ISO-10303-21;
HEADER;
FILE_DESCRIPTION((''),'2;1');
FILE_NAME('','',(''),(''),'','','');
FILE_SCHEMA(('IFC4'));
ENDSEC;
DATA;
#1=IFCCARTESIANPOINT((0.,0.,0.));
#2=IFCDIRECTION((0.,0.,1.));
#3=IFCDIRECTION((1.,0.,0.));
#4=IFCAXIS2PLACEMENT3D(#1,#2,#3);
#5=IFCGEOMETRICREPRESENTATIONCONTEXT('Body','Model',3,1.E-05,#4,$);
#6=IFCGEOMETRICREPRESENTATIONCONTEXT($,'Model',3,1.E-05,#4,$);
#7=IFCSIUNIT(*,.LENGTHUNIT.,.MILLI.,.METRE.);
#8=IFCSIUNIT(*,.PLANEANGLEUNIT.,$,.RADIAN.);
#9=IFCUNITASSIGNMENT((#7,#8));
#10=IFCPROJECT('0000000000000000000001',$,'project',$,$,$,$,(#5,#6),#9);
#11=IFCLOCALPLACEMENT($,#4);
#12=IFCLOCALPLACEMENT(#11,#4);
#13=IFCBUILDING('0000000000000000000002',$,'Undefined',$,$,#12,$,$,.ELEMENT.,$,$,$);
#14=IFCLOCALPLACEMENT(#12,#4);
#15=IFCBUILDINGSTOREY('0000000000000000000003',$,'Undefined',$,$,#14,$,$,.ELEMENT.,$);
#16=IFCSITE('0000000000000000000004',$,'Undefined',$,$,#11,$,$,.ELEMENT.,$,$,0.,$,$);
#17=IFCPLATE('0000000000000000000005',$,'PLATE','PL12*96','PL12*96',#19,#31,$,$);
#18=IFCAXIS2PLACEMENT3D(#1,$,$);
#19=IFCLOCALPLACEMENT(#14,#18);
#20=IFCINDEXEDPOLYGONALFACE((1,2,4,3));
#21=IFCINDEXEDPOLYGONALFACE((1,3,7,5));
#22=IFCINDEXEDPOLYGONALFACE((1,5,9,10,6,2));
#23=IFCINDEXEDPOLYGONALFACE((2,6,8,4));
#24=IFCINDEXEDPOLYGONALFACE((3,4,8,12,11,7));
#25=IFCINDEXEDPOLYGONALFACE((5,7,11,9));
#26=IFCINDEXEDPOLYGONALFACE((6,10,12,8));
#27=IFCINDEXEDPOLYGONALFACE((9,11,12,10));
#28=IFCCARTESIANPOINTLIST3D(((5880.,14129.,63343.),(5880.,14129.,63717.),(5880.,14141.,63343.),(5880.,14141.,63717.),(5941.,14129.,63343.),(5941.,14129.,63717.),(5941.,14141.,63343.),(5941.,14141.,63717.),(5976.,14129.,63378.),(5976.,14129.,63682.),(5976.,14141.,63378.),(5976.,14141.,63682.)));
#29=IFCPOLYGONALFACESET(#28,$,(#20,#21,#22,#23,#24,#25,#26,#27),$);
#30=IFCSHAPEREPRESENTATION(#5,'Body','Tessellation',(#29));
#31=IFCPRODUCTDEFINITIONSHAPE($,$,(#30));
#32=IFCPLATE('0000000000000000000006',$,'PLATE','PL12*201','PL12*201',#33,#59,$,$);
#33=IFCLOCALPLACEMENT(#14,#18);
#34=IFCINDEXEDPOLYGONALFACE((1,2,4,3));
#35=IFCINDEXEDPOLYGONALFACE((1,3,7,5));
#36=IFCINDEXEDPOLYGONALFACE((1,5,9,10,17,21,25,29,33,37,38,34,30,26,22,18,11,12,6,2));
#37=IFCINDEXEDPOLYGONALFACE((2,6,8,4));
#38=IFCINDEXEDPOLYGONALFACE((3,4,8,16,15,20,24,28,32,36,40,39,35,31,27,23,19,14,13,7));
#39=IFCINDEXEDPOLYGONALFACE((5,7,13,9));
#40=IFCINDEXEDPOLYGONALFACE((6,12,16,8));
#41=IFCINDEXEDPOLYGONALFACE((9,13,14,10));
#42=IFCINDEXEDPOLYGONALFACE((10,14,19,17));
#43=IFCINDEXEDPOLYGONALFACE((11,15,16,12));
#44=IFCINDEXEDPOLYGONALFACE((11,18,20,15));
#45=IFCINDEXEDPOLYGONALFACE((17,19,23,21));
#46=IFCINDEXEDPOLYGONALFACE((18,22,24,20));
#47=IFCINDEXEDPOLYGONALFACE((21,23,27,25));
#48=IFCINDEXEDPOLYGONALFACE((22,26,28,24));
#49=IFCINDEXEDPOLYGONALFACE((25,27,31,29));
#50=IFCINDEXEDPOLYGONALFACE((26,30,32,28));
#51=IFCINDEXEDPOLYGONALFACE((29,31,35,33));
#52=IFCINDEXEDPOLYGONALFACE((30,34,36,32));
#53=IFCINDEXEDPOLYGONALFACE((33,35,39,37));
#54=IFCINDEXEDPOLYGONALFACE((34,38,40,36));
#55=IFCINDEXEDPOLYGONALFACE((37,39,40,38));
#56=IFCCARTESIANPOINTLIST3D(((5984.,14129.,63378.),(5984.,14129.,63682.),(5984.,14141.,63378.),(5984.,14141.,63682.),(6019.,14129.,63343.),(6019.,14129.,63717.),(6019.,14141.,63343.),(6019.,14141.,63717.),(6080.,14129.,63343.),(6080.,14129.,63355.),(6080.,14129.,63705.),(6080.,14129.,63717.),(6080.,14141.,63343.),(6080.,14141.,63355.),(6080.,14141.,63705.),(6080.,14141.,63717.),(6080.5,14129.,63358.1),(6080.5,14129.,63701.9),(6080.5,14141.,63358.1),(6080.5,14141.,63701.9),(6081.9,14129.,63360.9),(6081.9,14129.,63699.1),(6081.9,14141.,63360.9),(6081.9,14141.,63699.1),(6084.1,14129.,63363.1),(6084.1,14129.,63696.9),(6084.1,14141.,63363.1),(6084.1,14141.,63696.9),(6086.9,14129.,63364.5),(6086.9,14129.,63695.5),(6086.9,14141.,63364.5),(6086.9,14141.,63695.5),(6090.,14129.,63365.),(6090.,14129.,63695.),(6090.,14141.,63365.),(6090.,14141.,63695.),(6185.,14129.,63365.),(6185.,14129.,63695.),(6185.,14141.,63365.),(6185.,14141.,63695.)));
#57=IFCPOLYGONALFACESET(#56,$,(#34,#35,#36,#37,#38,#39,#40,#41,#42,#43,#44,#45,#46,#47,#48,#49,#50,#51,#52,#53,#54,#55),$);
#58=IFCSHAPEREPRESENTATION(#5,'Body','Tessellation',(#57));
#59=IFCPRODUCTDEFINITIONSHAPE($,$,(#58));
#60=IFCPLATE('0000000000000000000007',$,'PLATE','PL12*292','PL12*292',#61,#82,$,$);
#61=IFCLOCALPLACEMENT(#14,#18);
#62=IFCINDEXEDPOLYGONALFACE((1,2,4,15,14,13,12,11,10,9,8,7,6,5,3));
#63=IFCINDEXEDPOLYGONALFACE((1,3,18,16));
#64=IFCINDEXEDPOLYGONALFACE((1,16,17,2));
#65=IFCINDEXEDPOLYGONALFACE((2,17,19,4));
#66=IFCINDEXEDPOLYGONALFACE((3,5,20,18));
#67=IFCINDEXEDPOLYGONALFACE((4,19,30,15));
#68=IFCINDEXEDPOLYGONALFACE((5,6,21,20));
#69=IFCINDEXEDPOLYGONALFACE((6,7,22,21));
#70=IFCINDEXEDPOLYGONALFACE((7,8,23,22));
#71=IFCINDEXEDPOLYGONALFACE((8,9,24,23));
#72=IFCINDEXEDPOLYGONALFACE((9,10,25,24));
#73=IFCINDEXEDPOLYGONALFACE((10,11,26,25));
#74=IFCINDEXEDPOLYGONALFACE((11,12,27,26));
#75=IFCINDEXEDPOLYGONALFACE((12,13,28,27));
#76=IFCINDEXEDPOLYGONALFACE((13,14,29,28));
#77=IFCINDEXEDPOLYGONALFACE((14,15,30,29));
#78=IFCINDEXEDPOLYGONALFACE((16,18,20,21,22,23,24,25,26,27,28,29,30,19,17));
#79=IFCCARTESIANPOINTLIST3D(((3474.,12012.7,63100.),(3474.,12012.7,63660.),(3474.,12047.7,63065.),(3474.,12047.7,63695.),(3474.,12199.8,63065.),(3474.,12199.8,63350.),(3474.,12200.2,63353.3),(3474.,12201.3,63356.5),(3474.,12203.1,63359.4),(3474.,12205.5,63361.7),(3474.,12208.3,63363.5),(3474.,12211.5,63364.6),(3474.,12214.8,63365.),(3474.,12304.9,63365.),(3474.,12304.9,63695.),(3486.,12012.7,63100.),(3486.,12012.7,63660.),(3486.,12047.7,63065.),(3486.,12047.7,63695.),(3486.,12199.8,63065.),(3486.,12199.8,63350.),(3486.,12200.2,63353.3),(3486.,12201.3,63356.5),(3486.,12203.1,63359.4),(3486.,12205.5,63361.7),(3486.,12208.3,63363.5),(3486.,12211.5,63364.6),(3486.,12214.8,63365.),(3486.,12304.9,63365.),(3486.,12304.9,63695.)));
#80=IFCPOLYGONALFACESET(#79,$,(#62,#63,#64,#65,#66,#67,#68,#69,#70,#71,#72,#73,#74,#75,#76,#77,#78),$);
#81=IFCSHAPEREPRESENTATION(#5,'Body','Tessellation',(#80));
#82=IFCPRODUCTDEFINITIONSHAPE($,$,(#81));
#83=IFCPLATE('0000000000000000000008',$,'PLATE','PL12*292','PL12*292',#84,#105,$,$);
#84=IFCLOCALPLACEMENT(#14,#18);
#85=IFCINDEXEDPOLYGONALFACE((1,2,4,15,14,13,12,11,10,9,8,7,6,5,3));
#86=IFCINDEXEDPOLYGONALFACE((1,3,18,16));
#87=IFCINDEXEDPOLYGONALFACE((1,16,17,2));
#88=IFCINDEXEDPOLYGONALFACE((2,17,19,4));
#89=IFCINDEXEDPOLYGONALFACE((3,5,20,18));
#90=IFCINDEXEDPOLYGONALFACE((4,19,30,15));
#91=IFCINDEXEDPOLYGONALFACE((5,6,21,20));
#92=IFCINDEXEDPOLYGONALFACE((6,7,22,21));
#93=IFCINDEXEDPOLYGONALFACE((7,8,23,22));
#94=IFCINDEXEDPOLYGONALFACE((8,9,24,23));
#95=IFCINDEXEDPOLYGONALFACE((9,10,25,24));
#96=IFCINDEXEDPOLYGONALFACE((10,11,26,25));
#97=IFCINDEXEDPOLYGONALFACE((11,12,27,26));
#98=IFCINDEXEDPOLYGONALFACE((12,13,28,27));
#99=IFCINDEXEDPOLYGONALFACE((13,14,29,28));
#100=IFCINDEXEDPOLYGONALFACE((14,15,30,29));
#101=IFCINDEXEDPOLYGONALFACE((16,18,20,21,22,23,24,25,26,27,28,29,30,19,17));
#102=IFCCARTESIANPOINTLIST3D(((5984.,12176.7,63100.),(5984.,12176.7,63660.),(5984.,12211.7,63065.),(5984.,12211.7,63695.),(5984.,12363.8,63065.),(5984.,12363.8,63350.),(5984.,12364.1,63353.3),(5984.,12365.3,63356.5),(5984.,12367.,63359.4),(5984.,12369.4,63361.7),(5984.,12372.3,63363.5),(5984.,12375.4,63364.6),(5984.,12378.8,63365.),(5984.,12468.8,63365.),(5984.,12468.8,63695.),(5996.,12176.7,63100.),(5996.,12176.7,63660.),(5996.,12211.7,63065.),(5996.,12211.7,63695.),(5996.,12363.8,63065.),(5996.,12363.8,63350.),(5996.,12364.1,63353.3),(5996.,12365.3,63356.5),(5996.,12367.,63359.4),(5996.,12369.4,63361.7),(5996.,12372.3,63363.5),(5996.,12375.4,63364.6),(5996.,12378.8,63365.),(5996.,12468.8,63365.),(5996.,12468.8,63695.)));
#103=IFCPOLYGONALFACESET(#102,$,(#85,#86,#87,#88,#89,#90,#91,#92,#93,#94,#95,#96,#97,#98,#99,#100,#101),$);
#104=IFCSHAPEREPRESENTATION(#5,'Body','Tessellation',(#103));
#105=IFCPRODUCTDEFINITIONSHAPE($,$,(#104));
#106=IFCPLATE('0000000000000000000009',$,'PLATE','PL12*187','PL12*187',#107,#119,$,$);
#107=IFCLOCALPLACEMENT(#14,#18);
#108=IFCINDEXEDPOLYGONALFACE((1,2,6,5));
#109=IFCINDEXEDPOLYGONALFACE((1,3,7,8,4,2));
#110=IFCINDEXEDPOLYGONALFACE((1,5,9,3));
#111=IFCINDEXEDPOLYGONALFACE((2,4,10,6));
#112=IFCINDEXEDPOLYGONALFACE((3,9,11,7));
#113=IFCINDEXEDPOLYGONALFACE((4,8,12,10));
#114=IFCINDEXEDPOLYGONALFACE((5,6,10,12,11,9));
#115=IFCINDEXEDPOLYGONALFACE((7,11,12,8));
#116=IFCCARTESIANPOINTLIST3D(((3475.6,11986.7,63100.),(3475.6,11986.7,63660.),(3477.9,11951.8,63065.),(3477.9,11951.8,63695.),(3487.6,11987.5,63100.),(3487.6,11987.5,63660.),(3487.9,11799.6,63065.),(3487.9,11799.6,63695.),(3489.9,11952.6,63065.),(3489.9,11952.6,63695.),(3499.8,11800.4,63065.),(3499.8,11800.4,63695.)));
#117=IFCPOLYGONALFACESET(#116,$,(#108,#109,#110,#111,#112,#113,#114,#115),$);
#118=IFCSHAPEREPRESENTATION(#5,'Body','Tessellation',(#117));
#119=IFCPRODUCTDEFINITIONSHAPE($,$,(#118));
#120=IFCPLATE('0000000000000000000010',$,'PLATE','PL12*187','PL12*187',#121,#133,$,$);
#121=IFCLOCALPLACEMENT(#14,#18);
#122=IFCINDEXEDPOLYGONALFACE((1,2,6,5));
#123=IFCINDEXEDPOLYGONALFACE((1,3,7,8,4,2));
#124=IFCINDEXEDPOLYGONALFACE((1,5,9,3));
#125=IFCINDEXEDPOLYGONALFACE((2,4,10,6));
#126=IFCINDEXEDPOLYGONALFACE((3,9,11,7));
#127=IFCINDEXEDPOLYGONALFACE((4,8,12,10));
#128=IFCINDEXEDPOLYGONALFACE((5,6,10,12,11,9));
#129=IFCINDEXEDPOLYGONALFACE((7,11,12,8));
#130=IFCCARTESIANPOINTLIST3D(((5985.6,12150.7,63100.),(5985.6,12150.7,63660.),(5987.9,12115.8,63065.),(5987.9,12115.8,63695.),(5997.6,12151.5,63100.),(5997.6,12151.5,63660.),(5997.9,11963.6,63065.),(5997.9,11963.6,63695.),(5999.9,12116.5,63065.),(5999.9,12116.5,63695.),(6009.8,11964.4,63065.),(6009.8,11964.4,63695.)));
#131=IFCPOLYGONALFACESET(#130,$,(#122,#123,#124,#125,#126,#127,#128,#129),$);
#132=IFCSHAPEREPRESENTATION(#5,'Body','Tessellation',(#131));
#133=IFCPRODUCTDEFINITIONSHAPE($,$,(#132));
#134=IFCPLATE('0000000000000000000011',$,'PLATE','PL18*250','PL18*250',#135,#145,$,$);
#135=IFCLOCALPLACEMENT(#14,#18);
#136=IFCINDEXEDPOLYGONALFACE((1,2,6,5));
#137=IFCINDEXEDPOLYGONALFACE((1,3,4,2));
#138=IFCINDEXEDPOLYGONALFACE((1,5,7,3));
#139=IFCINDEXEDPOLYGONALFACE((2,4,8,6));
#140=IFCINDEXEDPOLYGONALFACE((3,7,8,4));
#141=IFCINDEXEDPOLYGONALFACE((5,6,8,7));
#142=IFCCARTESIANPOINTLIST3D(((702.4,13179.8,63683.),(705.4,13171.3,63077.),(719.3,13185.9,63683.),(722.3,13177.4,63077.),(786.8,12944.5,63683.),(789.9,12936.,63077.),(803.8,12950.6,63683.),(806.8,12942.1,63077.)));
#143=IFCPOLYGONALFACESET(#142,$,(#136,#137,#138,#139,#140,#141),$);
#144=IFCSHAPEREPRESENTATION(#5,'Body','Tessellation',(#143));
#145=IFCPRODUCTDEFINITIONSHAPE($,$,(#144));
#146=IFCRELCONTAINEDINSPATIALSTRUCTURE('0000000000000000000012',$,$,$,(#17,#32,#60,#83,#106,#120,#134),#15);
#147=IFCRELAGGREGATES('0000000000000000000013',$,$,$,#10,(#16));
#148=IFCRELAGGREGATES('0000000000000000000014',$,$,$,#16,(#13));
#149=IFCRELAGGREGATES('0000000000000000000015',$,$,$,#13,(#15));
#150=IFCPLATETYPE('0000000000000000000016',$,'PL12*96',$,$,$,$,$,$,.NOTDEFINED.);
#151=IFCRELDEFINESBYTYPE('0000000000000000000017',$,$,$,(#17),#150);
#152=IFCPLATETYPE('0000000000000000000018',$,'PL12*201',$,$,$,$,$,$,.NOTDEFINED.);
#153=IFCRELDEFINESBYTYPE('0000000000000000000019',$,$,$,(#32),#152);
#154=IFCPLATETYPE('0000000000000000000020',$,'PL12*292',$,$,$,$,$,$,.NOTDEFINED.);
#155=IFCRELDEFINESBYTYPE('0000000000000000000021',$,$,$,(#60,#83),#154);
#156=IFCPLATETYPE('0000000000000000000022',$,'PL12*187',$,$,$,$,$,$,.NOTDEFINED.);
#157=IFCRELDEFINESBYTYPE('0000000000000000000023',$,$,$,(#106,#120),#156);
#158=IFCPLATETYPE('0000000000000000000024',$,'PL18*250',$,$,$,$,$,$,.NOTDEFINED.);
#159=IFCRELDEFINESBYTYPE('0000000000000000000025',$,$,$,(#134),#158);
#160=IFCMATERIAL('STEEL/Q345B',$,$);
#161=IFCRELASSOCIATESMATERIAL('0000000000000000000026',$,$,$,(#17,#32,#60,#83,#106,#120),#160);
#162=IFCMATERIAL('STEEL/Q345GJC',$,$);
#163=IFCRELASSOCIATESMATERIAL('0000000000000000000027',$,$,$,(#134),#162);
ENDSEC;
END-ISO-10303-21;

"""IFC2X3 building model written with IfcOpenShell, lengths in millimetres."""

from ifc_helpers import new_model, si_unit, frame, origin_with_axes, place, context, project, spatial, polyline, outline, extrude, material, type_object, element, save


model = new_model("IFC2X3")

# Units and contexts
model_context_1 = context("Model", 3, precision=1e-05, world=origin_with_axes(), identifier="Body")
model_context_2 = context("Model", 3, precision=1e-05, world=origin_with_axes())
ifc_project = project(units=[si_unit("LENGTHUNIT", "METRE", prefix="MILLI"), si_unit("PLANEANGLEUNIT", "RADIAN")], contexts=[model_context_1, model_context_2])

# Site, building, storey
site_placement = place(None, origin_with_axes())
site = spatial("IfcSite", under=ifc_project, at=site_placement, Name="Undefined", CompositionType="ELEMENT", RefElevation=0.0)
building_placement = place(site_placement, origin_with_axes())
building = spatial("IfcBuilding", under=site, at=building_placement, Name="Undefined", CompositionType="ELEMENT")
storey_placement = place(building_placement, origin_with_axes())
storey = spatial("IfcBuildingStorey", under=building, at=storey_placement, Name="Undefined", CompositionType="ELEMENT")

# Shared definitions
ifc_material_1 = material(Name="STEEL/Q345B")

# Shared definitions
ifc_material_2 = material(Name="STEEL/Q345GJC")

# Plates
plate_type_1 = type_object("IfcPlateType", Name="PL12*96", PredefinedType="NOTDEFINED")
plate_1_placement = place(storey_placement, frame((5976.0, 14135.0, 63343.0), z_axis=(0.0, 1.0, 0.0), x_axis=(-1.0, 0.0, 0.0)))
element("IfcPlate", 1, at=plate_1_placement, inside=storey, type_object=plate_type_1, material=ifc_material_1, Name="PLATE", Description="PL12*96", ObjectType="PL12*96", context=model_context_1, shape_type="SweptSolid", body=[
    extrude(outline(polyline([(0.0, 35.0), (35.0, 0.0), (96.0, 0.0), (96.0, 374.0), (35.0, 374.0), (0.0, 339.0), (0.0, 35.0)])), frame((0.0, 0.0, -6.0), z_axis=(0.0, 0.0, 1.0), x_axis=(1.0, 0.0, 0.0)), (0.0, 0.0, 1.0), 12.0),
])
plate_type_2 = type_object("IfcPlateType", Name="PL12*201", PredefinedType="NOTDEFINED")
plate_2_placement = place(storey_placement, frame((5984.0, 14135.0, 63378.0), z_axis=(0.0, -1.0, 0.0), x_axis=(0.707107, 0.0, -0.707107)))
element("IfcPlate", 2, at=plate_2_placement, inside=storey, type_object=plate_type_2, material=ifc_material_1, Name="PLATE", Description="PL12*201", ObjectType="PL12*201", context=model_context_1, shape_type="SweptSolid", body=[
    extrude(outline(polyline([(0.0, 0.0), (49.5, 0.0), (92.6, 43.1), (84.1, 51.6), (82.3, 54.1), (81.3, 57.1), (81.3, 60.3), (82.3, 63.2), (84.1, 65.8), (151.3, 132.9), (-82.0, 366.3), (-149.2, 299.1), (-151.7, 297.3), (-154.7, 296.3), (-157.8, 296.3), (-160.8, 297.3), (-163.3, 299.1), (-171.8, 307.6), (-215.0, 264.5), (-215.0, 215.0), (0.0, 0.0)])), frame((0.0, 0.0, -6.0), z_axis=(0.0, 0.0, 1.0), x_axis=(1.0, 0.0, 0.0)), (0.0, 0.0, 1.0), 12.0),
])
plate_type_3 = type_object("IfcPlateType", Name="PL12*292", PredefinedType="NOTDEFINED")
for number, where, z_axis, x_axis, name in (
    (3, (3480.0, 12304.9, 63695.0), (1.0, 0.0, 0.0), (0.0, -1.0, 0.0), "PLATE"),
    (4, (5990.0, 12468.8, 63695.0), (1.0, 0.0, 0.0), (0.0, -1.0, 0.0), "PLATE"),
):
    element("IfcPlate", number, at=place(storey_placement, frame(where, z_axis=z_axis, x_axis=x_axis)), inside=storey, type_object=plate_type_3, material=ifc_material_1, Name=name, Description="PL12*292", ObjectType="PL12*292", context=model_context_1, shape_type="SweptSolid", body=[
        extrude(outline(polyline([(0.0, 0.0), (257.2, 0.0), (292.2, 35.0), (292.2, 595.0), (257.2, 630.0), (105.1, 630.0), (105.1, 345.0), (104.7, 341.7), (103.6, 338.5), (101.8, 335.6), (99.4, 333.3), (96.6, 331.5), (93.4, 330.4), (90.1, 330.0), (0.0, 330.0), (0.0, 0.0)])), frame((0.0, 0.0, -6.0), z_axis=(0.0, 0.0, 1.0), x_axis=(1.0, 0.0, 0.0)), (0.0, 0.0, 1.0), 12.0),
    ])
plate_type_4 = type_object("IfcPlateType", Name="PL12*187", PredefinedType="NOTDEFINED")
for number, where, z_axis, x_axis, name in (
    (5, (3481.6, 11987.1, 63065.0), (-0.997873, -0.065183, 0.0), (0.065183, -0.997873, 0.0), "PLATE"),
    (6, (5991.6, 12151.1, 63065.0), (-0.997873, -0.065183, 0.0), (0.065183, -0.997873, 0.0), "PLATE"),
):
    element("IfcPlate", number, at=place(storey_placement, frame(where, z_axis=z_axis, x_axis=x_axis)), inside=storey, type_object=plate_type_4, material=ifc_material_1, Name=name, Description="PL12*187", ObjectType="PL12*187", context=model_context_1, shape_type="SweptSolid", body=[
        extrude(outline(polyline([(0.0, 35.0), (35.0, 0.0), (187.5, 0.0), (187.5, 630.0), (35.0, 630.0), (0.0, 595.0), (0.0, 35.0)])), frame((0.0, 0.0, -6.0), z_axis=(0.0, 0.0, 1.0), x_axis=(1.0, 0.0, 0.0)), (0.0, 0.0, 1.0), 12.0),
    ])
plate_type_5 = type_object("IfcPlateType", Name="PL18*250", PredefinedType="NOTDEFINED")
plate_3_placement = place(storey_placement, frame((710.8, 13182.9, 63683.0), z_axis=(0.941212, 0.337816, 0.0), x_axis=(0.337816, -0.941212, 0.0)))
element("IfcPlate", 7, at=plate_3_placement, inside=storey, type_object=plate_type_5, material=ifc_material_2, Name="PLATE", Description="PL18*250", ObjectType="PL18*250", context=model_context_1, shape_type="SweptSolid", body=[
    extrude(outline(polyline([(0.0, 0.0), (250.0, 0.0), (259.0, 606.0), (9.0, 606.0), (0.0, 0.0)])), frame((0.0, 0.0, -9.0), z_axis=(0.0, 0.0, 1.0), x_axis=(1.0, 0.0, 0.0)), (0.0, 0.0, 1.0), 18.0),
])

save(model, "model.ifc")
